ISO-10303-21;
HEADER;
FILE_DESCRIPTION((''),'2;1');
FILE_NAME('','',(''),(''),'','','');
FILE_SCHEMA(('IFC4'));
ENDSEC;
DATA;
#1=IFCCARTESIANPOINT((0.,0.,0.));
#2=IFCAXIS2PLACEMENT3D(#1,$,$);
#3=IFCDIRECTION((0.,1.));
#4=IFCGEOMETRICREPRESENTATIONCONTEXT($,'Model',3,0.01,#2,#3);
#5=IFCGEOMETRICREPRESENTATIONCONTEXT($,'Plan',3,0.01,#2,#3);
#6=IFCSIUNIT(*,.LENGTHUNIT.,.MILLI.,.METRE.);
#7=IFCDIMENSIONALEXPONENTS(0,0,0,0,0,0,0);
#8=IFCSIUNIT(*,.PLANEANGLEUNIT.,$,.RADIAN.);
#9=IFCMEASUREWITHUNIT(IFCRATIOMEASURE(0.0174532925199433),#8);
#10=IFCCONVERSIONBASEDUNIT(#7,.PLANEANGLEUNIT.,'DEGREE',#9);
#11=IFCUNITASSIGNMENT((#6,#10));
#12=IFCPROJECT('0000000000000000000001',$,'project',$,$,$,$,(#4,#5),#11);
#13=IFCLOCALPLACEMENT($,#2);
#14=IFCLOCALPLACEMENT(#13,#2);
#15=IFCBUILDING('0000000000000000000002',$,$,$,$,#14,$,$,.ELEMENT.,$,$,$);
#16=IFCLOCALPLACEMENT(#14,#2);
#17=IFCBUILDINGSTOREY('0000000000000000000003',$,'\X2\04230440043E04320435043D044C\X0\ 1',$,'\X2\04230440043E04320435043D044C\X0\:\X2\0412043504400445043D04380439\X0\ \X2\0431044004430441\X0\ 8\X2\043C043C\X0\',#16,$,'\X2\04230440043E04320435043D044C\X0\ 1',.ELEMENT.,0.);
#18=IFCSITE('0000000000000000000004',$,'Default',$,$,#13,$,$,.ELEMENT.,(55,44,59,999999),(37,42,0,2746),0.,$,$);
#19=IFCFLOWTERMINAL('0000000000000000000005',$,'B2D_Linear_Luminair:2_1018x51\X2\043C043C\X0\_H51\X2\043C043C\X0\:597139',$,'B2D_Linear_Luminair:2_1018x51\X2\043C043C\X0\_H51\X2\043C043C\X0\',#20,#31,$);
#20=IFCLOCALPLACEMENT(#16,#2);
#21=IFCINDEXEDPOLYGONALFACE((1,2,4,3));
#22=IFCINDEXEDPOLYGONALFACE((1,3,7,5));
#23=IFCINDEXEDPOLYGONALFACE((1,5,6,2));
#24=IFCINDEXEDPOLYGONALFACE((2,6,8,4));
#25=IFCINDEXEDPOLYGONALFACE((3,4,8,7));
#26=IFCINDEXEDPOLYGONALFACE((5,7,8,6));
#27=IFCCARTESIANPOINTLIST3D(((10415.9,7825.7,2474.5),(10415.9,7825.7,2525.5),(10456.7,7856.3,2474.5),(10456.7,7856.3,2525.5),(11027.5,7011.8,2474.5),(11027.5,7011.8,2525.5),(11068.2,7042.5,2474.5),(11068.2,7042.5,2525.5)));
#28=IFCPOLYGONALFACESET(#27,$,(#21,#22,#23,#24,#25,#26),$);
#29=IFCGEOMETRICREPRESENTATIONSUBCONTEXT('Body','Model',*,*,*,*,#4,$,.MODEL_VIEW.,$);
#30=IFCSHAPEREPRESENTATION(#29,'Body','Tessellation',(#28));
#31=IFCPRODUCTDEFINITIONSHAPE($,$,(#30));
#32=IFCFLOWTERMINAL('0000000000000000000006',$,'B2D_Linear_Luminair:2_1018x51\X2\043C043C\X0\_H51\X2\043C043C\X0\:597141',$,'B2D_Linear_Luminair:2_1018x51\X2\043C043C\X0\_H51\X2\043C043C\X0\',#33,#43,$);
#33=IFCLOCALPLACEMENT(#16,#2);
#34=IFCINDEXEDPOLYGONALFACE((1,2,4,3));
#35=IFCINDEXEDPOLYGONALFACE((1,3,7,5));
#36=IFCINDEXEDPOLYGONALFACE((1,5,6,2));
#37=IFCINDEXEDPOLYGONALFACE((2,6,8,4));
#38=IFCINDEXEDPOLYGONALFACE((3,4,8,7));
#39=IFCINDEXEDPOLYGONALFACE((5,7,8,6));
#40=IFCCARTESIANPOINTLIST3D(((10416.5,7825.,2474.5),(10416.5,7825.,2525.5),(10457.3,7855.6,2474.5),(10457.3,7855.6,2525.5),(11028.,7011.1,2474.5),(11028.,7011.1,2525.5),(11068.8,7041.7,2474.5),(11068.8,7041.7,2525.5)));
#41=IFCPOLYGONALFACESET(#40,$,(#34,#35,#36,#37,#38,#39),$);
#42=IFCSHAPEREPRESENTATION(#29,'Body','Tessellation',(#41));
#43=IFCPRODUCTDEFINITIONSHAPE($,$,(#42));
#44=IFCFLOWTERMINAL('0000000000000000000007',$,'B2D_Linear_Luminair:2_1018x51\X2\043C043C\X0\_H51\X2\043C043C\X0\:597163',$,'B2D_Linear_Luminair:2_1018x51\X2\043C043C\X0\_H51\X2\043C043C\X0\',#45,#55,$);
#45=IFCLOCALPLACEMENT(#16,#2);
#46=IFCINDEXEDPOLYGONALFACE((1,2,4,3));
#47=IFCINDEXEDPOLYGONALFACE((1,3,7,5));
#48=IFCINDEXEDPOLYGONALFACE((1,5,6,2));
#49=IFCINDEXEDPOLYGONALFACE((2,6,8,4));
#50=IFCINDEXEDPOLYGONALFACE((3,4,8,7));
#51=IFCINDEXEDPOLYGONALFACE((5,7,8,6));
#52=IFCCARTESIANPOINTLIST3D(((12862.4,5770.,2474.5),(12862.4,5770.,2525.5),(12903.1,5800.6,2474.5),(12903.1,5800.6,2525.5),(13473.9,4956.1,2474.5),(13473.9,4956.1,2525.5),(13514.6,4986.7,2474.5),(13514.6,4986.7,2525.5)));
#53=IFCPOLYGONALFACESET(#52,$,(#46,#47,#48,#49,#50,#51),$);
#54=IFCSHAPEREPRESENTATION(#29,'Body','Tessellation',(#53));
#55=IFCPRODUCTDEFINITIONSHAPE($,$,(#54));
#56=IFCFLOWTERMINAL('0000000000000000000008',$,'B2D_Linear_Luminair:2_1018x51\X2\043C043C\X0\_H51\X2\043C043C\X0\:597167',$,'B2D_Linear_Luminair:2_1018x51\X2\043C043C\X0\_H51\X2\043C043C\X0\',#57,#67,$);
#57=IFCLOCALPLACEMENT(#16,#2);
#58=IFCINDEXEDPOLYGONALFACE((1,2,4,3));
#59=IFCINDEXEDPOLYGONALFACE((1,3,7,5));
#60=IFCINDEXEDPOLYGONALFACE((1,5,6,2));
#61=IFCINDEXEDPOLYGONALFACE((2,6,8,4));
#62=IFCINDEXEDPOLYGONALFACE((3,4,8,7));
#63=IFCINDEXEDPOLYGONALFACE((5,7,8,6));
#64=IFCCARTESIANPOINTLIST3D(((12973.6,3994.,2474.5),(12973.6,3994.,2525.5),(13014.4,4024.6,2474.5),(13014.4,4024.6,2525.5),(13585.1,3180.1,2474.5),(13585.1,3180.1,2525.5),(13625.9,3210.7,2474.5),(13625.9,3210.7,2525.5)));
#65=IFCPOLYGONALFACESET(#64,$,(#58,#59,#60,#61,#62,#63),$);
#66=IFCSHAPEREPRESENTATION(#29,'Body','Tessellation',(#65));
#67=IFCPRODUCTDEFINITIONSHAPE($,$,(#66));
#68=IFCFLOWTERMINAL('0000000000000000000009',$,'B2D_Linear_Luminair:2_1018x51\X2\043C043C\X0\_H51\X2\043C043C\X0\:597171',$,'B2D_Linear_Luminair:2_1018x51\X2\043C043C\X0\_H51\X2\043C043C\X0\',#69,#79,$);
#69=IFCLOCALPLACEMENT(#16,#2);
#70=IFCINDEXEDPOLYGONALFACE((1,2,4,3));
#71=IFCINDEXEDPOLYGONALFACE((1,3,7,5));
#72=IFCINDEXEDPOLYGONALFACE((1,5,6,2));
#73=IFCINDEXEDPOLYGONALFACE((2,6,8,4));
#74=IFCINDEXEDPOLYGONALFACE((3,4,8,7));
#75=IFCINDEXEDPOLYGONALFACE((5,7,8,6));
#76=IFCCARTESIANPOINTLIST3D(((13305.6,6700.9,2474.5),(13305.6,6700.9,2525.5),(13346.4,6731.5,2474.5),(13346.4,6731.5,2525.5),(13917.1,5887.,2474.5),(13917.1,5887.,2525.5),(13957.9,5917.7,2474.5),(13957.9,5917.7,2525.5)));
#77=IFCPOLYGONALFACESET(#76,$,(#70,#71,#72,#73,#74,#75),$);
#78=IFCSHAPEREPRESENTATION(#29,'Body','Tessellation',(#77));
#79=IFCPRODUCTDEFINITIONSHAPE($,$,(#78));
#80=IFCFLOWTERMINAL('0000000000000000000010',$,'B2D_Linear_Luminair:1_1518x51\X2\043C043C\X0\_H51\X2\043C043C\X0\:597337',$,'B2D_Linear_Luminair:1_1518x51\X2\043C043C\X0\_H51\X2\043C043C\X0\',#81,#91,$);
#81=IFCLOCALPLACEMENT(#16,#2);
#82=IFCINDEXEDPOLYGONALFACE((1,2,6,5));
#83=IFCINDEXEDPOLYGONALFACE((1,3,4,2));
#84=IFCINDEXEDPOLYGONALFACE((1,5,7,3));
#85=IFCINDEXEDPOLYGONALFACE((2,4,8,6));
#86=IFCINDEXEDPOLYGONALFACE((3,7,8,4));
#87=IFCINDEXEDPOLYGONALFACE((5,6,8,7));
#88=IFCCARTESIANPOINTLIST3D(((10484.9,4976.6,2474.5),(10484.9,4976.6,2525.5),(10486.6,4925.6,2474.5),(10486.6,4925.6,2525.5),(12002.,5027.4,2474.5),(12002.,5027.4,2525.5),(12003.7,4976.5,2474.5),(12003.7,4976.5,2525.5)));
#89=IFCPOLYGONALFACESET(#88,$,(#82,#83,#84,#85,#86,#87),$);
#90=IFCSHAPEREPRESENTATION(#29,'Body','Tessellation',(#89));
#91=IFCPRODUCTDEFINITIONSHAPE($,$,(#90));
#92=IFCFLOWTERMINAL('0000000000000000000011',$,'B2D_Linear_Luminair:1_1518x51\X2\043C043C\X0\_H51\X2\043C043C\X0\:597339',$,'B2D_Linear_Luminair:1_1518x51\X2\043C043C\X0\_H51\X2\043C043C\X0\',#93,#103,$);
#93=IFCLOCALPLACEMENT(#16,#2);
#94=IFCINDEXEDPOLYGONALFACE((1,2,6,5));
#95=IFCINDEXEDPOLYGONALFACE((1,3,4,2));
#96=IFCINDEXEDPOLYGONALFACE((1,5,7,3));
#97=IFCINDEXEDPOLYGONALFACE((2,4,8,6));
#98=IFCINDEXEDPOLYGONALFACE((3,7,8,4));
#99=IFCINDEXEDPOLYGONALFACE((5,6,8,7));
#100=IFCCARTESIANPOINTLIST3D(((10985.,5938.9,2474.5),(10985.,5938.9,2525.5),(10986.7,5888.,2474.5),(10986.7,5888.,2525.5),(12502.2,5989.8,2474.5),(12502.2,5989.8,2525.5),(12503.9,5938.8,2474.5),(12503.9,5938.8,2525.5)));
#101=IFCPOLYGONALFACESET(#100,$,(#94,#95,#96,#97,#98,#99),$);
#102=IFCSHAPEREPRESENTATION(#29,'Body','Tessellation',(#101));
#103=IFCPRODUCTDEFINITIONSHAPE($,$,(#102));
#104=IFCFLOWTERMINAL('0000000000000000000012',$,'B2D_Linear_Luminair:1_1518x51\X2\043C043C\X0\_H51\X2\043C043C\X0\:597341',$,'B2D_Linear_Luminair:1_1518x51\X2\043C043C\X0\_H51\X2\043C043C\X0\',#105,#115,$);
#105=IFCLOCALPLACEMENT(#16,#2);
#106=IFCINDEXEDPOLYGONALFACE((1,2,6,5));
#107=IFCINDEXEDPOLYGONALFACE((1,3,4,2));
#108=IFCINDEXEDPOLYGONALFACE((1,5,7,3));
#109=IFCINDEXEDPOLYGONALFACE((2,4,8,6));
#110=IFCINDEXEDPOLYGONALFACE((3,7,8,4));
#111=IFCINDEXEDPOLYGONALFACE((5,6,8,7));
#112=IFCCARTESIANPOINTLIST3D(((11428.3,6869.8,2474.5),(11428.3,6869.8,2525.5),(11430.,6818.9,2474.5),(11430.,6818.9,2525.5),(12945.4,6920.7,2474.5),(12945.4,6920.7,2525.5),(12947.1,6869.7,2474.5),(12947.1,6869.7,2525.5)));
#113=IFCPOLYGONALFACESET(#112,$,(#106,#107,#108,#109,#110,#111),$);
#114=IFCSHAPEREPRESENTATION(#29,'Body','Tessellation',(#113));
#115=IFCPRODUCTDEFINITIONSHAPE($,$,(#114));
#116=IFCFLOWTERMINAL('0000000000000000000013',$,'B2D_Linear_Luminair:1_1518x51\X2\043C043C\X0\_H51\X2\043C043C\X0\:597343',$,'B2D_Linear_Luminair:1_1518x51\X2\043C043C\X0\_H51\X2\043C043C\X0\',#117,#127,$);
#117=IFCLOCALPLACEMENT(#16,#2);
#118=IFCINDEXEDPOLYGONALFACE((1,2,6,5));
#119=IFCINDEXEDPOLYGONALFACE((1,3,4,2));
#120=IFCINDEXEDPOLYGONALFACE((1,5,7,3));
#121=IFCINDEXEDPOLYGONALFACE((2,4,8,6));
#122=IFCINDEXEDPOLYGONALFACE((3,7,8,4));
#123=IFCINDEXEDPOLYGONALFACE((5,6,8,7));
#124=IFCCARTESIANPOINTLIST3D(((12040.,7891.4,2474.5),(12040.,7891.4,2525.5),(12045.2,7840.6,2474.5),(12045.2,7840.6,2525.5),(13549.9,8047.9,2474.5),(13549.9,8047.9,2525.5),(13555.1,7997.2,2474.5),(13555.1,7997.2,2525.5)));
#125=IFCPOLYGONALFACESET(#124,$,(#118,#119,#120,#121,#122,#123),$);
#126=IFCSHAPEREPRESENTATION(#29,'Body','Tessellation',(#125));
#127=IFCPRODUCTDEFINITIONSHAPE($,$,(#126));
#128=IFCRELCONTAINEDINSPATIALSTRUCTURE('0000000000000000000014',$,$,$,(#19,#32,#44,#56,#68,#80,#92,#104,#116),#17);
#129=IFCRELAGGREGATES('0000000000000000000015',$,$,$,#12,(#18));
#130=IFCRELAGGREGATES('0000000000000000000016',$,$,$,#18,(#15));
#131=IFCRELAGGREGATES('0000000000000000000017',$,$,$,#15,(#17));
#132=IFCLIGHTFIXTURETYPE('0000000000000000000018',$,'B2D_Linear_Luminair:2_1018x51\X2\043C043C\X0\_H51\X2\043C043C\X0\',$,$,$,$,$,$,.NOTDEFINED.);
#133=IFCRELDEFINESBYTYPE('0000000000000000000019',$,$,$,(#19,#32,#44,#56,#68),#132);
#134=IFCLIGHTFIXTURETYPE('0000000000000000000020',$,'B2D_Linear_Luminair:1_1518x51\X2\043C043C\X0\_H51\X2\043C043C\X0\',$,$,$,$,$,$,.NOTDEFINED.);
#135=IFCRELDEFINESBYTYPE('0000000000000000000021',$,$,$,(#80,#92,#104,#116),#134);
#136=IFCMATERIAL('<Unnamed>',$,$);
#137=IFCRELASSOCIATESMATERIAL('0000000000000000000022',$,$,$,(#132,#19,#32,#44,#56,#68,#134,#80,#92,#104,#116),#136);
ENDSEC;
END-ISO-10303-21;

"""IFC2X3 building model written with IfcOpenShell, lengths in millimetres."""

from ifc_helpers import new_model, entity, si_unit, converted_unit, direction, frame, origin, origin_2d_with_axis, place, context, subcontext, project, spatial, rectangle, extrude, source, transform, mapped, material, type_object, type_shapes, element, save


model = new_model("IFC2X3")

# Units and contexts
model_context = context("Model", 3, precision=0.01, world=origin(), true_north=direction((0.0, 1.0)))
plan_context = context("Plan", 3, precision=0.01, world=origin(), true_north=direction((0.0, 1.0)))
body_context = subcontext(model_context, "Body", "Model", "MODEL_VIEW")
ifc_project = project(units=[si_unit("LENGTHUNIT", "METRE", prefix="MILLI"), converted_unit("PLANEANGLEUNIT", "DEGREE", entity("IfcRatioMeasure", 0.0174532925199433), si_unit("PLANEANGLEUNIT", "RADIAN"), dimensions=[0, 0, 0, 0, 0, 0, 0])], contexts=[model_context, plan_context])

# Site, building, storey
site_placement = place(None, origin())
site = spatial("IfcSite", under=ifc_project, at=site_placement, Name="Default", CompositionType="ELEMENT", RefLatitude=(55, 44, 59, 999999), RefLongitude=(37, 42, 0, 2746), RefElevation=0.0)
building_placement = place(site_placement, origin())
building = spatial("IfcBuilding", under=site, at=building_placement, CompositionType="ELEMENT")
storey_placement = place(building_placement, origin())
storey = spatial("IfcBuildingStorey", under=building, at=storey_placement, Name="Уровень 1", ObjectType="Уровень:Верхний брус 8мм", LongName="Уровень 1", CompositionType="ELEMENT", Elevation=0.0)

# Flow terminals
ifc_material = material(Name="<Unnamed>")
light_fixture_type_1 = type_object("IfcLightFixtureType", Name="B2D_Linear_Luminair:2_1018x51мм_H51мм", PredefinedType="NOTDEFINED", material=ifc_material)
shared_shape_1 = source(origin(), body_context, "Body", "SweptSolid", [
    extrude(rectangle(XDim=1018.0, YDim=51.0, at=origin_2d_with_axis()), frame((0.0, 0.0, 0.0), z_axis=(0.0, 0.0, 1.0), x_axis=(-1.0, 0.0, 0.0)), (0.0, 0.0, 1.0), 51.0),
])
type_shapes(light_fixture_type_1, [shared_shape_1])
for number, where, z_axis, x_axis, name in (
    (1, (10742.1, 7434.1, 2525.5), (0.0, 0.0, -1.0), (0.600699, -0.799475, 0.0), "B2D_Linear_Luminair:2_1018x51мм_H51мм:597139"),
    (2, (10742.6, 7433.4, 2525.5), (0.0, 0.0, -1.0), (0.600699, -0.799475, 0.0), "B2D_Linear_Luminair:2_1018x51мм_H51мм:597141"),
    (3, (13188.5, 5378.4, 2525.5), (0.0, 0.0, -1.0), (0.600699, -0.799475, 0.0), "B2D_Linear_Luminair:2_1018x51мм_H51мм:597163"),
    (4, (13299.8, 3602.4, 2525.5), (0.0, 0.0, -1.0), (0.600699, -0.799475, 0.0), "B2D_Linear_Luminair:2_1018x51мм_H51мм:597167"),
    (5, (13631.8, 6309.3, 2525.5), (0.0, 0.0, -1.0), (0.600699, -0.799475, 0.0), "B2D_Linear_Luminair:2_1018x51мм_H51мм:597171"),
):
    element("IfcFlowTerminal", number, at=place(storey_placement, frame(where, z_axis=z_axis, x_axis=x_axis)), inside=storey, type_object=light_fixture_type_1, material=ifc_material, Name=name, ObjectType="B2D_Linear_Luminair:2_1018x51мм_H51мм", context=body_context, shape_type="MappedRepresentation", body=[
        mapped(shared_shape_1, transform((0.0, 0.0, 0.0), scale=1.0)),
    ])
light_fixture_type_2 = type_object("IfcLightFixtureType", Name="B2D_Linear_Luminair:1_1518x51мм_H51мм", PredefinedType="NOTDEFINED", material=ifc_material)
shared_shape_2 = source(origin(), body_context, "Body", "SweptSolid", [
    extrude(rectangle(XDim=1518.0, YDim=51.0, at=origin_2d_with_axis()), frame((0.0, 0.0, 0.0), z_axis=(0.0, 0.0, 1.0), x_axis=(-1.0, 0.0, 0.0)), (0.0, 0.0, 1.0), 51.0),
])
type_shapes(light_fixture_type_2, [shared_shape_2])
for number, where, z_axis, x_axis, name in (
    (6, (11244.3, 4976.5, 2525.5), (0.0, 0.0, -1.0), (0.999439, 0.033504, 0.0), "B2D_Linear_Luminair:1_1518x51мм_H51мм:597337"),
    (7, (11744.4, 5938.9, 2525.5), (0.0, 0.0, -1.0), (0.999439, 0.033504, 0.0), "B2D_Linear_Luminair:1_1518x51мм_H51мм:597339"),
    (8, (12187.7, 6869.8, 2525.5), (0.0, 0.0, -1.0), (0.999439, 0.033504, 0.0), "B2D_Linear_Luminair:1_1518x51мм_H51мм:597341"),
    (9, (12797.5, 7944.3, 2525.5), (0.0, 0.0, -1.0), (0.994667, 0.10314, 0.0), "B2D_Linear_Luminair:1_1518x51мм_H51мм:597343"),
):
    element("IfcFlowTerminal", number, at=place(storey_placement, frame(where, z_axis=z_axis, x_axis=x_axis)), inside=storey, type_object=light_fixture_type_2, material=ifc_material, Name=name, ObjectType="B2D_Linear_Luminair:1_1518x51мм_H51мм", context=body_context, shape_type="MappedRepresentation", body=[
        mapped(shared_shape_2, transform((0.0, 0.0, 0.0), scale=1.0)),
    ])

save(model, "model.ifc")
